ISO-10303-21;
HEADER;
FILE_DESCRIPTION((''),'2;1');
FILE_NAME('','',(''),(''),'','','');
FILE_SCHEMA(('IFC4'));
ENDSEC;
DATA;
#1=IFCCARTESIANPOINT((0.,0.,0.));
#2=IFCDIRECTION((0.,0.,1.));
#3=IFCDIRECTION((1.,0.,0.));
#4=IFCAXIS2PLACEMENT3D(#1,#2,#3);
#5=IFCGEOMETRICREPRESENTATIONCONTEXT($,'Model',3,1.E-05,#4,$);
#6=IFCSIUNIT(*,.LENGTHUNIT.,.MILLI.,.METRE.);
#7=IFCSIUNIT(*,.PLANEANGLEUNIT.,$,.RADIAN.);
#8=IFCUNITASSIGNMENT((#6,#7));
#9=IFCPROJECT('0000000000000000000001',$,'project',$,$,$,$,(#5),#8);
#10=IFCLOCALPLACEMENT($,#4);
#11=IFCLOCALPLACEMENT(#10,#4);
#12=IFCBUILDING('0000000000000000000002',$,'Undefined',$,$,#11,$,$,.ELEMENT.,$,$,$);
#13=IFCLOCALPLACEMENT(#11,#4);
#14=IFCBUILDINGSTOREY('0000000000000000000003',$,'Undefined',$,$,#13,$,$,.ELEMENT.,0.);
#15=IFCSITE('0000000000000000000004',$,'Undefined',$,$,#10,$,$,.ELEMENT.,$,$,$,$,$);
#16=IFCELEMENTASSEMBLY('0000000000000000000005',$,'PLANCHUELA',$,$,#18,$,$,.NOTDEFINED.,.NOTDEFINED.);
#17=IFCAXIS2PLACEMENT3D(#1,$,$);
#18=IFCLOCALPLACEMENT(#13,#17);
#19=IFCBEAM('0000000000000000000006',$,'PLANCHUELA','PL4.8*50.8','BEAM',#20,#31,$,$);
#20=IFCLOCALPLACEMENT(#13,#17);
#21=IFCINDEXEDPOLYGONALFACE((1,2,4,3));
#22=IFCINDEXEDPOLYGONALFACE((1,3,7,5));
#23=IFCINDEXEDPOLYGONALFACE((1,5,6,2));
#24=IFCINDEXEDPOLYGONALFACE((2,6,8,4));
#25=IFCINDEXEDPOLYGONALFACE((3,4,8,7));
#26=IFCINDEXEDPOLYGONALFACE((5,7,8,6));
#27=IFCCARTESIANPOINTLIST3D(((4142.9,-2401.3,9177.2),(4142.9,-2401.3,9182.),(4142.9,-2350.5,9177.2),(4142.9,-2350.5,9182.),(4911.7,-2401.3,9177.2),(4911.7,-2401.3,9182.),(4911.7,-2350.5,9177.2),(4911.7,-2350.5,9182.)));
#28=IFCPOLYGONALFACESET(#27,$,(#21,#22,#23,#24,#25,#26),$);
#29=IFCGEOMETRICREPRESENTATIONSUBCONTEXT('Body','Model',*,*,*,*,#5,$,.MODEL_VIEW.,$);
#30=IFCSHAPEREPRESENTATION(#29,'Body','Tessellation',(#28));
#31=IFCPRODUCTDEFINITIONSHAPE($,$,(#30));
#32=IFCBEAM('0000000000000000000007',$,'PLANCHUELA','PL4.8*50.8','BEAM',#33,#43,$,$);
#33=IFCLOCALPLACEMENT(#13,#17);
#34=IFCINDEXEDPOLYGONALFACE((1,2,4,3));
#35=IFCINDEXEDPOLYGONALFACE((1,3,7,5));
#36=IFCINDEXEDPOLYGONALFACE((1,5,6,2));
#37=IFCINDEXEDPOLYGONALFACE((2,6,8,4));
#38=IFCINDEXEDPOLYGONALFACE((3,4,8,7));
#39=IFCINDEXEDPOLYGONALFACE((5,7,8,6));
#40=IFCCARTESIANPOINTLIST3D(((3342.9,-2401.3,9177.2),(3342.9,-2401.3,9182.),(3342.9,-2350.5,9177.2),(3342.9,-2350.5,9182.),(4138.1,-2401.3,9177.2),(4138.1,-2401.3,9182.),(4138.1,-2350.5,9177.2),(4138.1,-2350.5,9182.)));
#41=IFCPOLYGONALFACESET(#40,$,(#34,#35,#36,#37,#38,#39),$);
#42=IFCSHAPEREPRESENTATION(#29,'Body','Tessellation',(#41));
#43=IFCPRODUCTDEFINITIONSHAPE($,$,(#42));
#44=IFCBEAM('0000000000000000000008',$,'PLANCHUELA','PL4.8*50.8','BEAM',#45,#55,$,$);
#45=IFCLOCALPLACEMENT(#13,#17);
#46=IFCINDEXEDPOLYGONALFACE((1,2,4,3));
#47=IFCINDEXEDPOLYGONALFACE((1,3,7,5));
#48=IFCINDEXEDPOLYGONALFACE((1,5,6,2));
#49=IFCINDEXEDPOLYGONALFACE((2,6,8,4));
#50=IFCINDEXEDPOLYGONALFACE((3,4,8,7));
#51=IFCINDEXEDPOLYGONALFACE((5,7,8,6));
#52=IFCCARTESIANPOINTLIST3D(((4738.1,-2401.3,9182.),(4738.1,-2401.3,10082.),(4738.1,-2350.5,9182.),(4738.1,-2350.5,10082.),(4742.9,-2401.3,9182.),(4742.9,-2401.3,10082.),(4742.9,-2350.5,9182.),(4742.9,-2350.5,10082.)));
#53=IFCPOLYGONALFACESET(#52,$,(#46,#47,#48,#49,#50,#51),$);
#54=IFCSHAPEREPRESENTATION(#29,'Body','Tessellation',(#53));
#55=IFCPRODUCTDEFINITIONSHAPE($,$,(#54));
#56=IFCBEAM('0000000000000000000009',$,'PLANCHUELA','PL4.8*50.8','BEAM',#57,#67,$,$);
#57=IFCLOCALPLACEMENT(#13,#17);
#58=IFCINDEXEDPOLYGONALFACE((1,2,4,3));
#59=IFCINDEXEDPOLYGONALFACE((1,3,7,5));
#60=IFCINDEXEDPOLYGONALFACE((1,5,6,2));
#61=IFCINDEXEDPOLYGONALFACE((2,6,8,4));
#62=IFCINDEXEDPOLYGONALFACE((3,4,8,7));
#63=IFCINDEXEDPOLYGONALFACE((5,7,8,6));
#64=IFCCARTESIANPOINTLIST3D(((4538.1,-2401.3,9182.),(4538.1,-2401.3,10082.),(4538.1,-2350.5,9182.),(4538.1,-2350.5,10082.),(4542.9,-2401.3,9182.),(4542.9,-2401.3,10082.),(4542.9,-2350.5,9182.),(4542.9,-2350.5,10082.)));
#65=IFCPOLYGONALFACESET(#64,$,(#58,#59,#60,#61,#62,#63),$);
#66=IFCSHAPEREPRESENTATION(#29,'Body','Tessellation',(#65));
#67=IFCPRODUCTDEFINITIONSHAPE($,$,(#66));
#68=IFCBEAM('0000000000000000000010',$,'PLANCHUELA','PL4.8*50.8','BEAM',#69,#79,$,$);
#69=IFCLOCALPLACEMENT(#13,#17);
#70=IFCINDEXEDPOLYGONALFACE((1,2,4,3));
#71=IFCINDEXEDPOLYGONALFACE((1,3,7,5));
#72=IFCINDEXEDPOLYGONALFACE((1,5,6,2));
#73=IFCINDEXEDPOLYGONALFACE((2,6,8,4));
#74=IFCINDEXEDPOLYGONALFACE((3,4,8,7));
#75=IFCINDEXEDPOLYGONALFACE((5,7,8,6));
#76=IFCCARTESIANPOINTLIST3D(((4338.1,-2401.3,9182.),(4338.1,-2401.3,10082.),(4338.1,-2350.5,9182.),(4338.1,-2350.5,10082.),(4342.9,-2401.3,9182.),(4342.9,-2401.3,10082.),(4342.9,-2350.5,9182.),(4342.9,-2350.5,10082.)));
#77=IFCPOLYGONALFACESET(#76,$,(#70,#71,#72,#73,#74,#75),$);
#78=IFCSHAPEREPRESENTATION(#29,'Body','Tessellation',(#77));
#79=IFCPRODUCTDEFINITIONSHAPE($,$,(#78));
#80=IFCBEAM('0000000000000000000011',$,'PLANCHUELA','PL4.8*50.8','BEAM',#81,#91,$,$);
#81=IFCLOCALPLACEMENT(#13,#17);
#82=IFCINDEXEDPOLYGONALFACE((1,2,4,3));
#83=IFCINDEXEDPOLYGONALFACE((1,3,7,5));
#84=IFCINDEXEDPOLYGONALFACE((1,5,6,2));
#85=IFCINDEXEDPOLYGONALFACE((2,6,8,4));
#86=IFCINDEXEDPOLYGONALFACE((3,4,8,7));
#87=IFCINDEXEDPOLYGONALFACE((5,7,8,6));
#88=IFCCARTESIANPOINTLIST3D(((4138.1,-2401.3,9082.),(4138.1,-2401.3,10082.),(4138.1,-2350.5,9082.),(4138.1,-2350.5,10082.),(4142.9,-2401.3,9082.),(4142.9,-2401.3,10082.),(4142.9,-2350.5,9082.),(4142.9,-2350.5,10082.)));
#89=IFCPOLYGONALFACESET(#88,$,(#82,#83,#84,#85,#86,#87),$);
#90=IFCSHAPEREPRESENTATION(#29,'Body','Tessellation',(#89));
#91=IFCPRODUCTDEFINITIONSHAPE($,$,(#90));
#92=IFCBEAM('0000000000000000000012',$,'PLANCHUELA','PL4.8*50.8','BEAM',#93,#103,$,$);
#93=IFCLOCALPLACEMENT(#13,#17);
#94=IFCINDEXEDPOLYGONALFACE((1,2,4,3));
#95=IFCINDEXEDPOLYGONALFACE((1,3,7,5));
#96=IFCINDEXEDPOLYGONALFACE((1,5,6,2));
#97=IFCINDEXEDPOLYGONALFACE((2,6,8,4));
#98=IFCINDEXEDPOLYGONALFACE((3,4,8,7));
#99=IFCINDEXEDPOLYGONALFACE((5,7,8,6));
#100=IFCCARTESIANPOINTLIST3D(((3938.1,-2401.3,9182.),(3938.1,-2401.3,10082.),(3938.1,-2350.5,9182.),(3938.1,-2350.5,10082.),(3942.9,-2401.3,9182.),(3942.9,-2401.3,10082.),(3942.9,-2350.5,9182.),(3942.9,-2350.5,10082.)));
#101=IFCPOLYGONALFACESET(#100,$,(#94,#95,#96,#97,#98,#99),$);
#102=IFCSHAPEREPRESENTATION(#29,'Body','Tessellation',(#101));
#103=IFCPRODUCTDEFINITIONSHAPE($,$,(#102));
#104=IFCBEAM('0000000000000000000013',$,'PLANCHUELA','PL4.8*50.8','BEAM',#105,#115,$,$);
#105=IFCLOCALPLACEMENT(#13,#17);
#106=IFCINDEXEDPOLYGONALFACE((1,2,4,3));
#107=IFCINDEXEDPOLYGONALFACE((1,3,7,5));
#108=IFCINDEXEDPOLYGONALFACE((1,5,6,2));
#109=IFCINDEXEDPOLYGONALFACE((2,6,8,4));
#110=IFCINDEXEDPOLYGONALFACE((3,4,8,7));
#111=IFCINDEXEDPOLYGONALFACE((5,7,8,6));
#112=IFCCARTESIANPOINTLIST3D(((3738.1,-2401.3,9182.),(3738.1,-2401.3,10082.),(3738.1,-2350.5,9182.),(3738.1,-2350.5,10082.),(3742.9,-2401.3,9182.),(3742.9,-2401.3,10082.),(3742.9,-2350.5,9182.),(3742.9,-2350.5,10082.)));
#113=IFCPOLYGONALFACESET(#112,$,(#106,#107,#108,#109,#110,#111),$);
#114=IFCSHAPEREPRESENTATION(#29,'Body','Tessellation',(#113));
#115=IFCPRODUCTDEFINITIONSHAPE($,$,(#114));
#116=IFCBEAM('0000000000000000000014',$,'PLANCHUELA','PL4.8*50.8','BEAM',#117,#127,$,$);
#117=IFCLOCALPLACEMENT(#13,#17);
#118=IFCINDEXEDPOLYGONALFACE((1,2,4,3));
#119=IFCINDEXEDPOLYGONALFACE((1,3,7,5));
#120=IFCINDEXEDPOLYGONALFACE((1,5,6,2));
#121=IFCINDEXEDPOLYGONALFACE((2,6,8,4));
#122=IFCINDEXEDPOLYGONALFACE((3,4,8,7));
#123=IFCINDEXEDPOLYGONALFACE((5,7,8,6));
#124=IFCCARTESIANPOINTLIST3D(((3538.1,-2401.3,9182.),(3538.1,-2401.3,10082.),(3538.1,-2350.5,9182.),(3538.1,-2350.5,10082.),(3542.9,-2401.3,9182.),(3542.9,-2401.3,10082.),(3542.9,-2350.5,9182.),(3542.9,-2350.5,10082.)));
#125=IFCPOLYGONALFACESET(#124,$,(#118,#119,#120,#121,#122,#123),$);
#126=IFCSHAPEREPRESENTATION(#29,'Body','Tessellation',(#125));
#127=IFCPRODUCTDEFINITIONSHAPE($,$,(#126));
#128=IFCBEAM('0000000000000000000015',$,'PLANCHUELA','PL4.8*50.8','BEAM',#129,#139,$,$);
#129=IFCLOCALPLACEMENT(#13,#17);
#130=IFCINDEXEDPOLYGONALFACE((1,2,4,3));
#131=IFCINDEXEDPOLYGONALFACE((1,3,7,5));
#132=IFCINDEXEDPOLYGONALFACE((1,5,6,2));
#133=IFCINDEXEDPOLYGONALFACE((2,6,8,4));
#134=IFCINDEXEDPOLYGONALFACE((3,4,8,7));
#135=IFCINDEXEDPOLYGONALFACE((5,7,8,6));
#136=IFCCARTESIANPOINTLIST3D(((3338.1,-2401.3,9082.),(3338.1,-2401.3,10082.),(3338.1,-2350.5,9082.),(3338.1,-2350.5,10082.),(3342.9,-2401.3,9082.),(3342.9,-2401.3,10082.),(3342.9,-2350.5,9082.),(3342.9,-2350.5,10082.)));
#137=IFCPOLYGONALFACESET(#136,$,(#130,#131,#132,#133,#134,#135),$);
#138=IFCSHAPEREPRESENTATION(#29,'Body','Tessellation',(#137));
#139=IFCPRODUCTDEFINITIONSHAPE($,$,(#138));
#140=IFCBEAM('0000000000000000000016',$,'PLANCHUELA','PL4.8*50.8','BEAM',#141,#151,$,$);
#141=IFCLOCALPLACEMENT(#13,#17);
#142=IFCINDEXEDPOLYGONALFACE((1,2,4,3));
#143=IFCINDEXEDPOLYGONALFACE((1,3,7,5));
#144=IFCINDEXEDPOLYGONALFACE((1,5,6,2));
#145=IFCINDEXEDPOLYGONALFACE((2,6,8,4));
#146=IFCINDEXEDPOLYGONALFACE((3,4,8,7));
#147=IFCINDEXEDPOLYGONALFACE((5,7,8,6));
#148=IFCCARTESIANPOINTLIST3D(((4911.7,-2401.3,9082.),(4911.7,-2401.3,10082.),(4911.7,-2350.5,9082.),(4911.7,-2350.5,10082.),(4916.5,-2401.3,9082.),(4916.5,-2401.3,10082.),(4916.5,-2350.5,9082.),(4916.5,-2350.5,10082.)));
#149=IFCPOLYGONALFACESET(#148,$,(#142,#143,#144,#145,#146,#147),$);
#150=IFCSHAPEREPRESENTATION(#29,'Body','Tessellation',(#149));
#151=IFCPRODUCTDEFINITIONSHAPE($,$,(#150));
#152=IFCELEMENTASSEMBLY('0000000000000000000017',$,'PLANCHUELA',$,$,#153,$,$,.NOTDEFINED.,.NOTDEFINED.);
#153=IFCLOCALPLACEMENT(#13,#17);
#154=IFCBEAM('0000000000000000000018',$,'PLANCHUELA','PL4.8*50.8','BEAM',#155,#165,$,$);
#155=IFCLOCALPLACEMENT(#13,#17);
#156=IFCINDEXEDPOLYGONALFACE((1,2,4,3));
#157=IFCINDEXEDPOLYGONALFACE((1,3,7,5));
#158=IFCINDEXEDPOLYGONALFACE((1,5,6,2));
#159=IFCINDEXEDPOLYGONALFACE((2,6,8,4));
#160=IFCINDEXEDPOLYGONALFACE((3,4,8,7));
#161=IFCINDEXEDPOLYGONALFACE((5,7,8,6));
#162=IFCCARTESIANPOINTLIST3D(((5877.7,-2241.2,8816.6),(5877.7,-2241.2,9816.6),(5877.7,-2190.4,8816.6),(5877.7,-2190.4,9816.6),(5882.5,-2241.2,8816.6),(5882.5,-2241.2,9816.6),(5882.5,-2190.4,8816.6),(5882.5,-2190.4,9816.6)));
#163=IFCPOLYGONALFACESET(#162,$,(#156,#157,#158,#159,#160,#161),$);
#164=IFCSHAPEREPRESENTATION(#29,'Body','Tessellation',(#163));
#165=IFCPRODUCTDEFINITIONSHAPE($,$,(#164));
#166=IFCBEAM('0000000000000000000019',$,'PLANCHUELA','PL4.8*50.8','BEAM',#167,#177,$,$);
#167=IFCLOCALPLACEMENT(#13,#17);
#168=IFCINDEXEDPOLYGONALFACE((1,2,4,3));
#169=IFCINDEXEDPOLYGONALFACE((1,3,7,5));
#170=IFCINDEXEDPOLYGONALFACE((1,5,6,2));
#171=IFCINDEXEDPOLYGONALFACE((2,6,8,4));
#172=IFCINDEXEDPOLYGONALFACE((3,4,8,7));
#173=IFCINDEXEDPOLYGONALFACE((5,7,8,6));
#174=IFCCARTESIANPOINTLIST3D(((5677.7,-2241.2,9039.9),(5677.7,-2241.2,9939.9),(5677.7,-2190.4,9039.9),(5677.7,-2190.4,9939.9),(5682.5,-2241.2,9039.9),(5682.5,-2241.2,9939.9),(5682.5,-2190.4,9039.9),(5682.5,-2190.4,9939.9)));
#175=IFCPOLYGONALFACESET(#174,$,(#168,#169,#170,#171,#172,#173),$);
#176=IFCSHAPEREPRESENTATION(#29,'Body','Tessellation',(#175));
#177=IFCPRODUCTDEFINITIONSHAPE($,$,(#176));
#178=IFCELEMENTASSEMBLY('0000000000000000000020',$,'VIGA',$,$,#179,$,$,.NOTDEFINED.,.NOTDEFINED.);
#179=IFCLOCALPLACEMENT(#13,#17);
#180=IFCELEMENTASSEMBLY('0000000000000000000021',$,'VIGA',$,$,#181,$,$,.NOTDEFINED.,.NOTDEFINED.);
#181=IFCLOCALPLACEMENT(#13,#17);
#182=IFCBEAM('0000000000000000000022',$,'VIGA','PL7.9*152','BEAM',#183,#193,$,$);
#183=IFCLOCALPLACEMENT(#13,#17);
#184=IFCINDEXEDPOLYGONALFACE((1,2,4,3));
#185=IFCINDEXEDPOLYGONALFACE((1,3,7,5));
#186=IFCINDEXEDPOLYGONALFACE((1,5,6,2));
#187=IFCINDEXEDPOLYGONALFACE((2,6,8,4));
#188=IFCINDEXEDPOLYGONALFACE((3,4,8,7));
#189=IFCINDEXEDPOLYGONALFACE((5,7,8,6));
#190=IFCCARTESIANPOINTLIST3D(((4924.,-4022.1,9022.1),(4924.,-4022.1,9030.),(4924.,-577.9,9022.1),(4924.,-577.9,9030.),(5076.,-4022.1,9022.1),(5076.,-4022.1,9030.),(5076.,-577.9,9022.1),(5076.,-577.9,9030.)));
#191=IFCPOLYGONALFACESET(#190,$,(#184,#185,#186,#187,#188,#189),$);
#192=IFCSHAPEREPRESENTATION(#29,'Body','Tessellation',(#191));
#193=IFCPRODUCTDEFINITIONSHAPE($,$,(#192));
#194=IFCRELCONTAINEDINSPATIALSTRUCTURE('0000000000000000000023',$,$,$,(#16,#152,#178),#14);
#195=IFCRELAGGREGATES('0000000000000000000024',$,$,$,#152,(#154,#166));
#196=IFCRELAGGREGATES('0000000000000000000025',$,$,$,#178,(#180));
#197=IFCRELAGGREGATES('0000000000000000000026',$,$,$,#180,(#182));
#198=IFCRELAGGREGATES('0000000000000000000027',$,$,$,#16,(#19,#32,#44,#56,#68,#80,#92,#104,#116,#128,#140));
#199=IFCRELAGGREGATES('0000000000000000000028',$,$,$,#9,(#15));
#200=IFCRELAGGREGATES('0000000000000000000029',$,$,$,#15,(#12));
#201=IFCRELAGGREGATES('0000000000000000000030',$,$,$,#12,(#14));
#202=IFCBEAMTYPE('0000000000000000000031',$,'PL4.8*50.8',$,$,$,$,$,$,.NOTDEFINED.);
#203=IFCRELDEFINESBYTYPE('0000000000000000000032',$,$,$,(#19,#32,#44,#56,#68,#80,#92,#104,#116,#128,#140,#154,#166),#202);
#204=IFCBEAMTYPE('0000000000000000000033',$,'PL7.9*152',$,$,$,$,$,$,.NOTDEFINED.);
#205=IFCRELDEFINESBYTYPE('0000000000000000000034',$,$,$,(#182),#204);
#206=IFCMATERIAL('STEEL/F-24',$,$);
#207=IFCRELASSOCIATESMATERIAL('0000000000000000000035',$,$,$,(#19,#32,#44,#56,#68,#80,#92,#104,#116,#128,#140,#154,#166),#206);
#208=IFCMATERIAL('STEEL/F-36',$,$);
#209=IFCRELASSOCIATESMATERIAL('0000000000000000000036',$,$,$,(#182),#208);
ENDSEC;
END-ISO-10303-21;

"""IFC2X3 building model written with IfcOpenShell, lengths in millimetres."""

from ifc_helpers import new_model, si_unit, frame, origin_with_axes, origin_2d_with_axis, place, context, subcontext, project, spatial, rectangle, extrude, material, type_object, element, aggregate, save


model = new_model("IFC2X3")

# Units and contexts
model_context = context("Model", 3, precision=1e-05, world=origin_with_axes())
body_context = subcontext(model_context, "Body", "Model", "MODEL_VIEW")
ifc_project = project(units=[si_unit("LENGTHUNIT", "METRE", prefix="MILLI"), si_unit("PLANEANGLEUNIT", "RADIAN")], contexts=[model_context])

# Site, building, storey
site_placement = place(None, origin_with_axes())
site = spatial("IfcSite", under=ifc_project, at=site_placement, Name="Undefined", CompositionType="ELEMENT")
building_placement = place(site_placement, origin_with_axes())
building = spatial("IfcBuilding", under=site, at=building_placement, Name="Undefined", CompositionType="ELEMENT")
storey_placement = place(building_placement, origin_with_axes())
storey = spatial("IfcBuildingStorey", under=building, at=storey_placement, Name="Undefined", CompositionType="ELEMENT", Elevation=0.0)

# Element assemblies, beams
assembly_1_placement = place(storey_placement, origin_with_axes())
assembly_1 = element("IfcElementAssembly", 1, at=assembly_1_placement, inside=storey, Name="PLANCHUELA", AssemblyPlace="NOTDEFINED", PredefinedType="NOTDEFINED")
ifc_material_1 = material(Name="STEEL/F-24")
beam_type_1 = type_object("IfcBeamType", Name="PL4.8*50.8", PredefinedType="NOTDEFINED")
beam_1_placement = place(assembly_1_placement, frame((4142.9, -2375.9, 9179.6), z_axis=(0.0, -1.0, 0.0), x_axis=(1.0, 0.0, 0.0)))
beam_1 = element("IfcBeam", 2, at=beam_1_placement, type_object=beam_type_1, material=ifc_material_1, Name="PLANCHUELA", Description="PL4.8*50.8", ObjectType="BEAM", context=body_context, shape_type="SweptSolid", body=[
    extrude(rectangle(XDim=4.8, YDim=50.8, at=origin_2d_with_axis()), frame((768.8, 0.0, 0.0), z_axis=(-1.0, 0.0, 0.0), x_axis=(0.0, -1.0, 0.0)), (0.0, 0.0, 1.0), 768.8),
])
beam_2_placement = place(assembly_1_placement, frame((3342.9, -2375.9, 9179.6), z_axis=(0.0, -1.0, 0.0), x_axis=(1.0, 0.0, 0.0)))
beam_2 = element("IfcBeam", 3, at=beam_2_placement, type_object=beam_type_1, material=ifc_material_1, Name="PLANCHUELA", Description="PL4.8*50.8", ObjectType="BEAM", context=body_context, shape_type="SweptSolid", body=[
    extrude(rectangle(XDim=4.8, YDim=50.8, at=origin_2d_with_axis()), frame((795.2, 0.0, 0.0), z_axis=(-1.0, 0.0, 0.0), x_axis=(0.0, -1.0, 0.0)), (0.0, 0.0, 1.0), 795.2),
])
beam_3_placement = place(assembly_1_placement, frame((4740.5, -2375.9, 10082.0), z_axis=(0.0, -1.0, 0.0), x_axis=(0.0, 0.0, -1.0)))
beam_3 = element("IfcBeam", 4, at=beam_3_placement, type_object=beam_type_1, material=ifc_material_1, Name="PLANCHUELA", Description="PL4.8*50.8", ObjectType="BEAM", context=body_context, shape_type="SweptSolid", body=[
    extrude(rectangle(XDim=4.8, YDim=50.8, at=origin_2d_with_axis()), frame((900.0, 0.0, 0.0), z_axis=(-1.0, 0.0, 0.0), x_axis=(0.0, -1.0, 0.0)), (0.0, 0.0, 1.0), 900.0),
])
beam_4_placement = place(assembly_1_placement, frame((4540.5, -2375.9, 10082.0), z_axis=(0.0, -1.0, 0.0), x_axis=(0.0, 0.0, -1.0)))
beam_4 = element("IfcBeam", 5, at=beam_4_placement, type_object=beam_type_1, material=ifc_material_1, Name="PLANCHUELA", Description="PL4.8*50.8", ObjectType="BEAM", context=body_context, shape_type="SweptSolid", body=[
    extrude(rectangle(XDim=4.8, YDim=50.8, at=origin_2d_with_axis()), frame((900.0, 0.0, 0.0), z_axis=(-1.0, 0.0, 0.0), x_axis=(0.0, -1.0, 0.0)), (0.0, 0.0, 1.0), 900.0),
])
beam_5_placement = place(assembly_1_placement, frame((4340.5, -2375.9, 10082.0), z_axis=(0.0, -1.0, 0.0), x_axis=(0.0, 0.0, -1.0)))
beam_5 = element("IfcBeam", 6, at=beam_5_placement, type_object=beam_type_1, material=ifc_material_1, Name="PLANCHUELA", Description="PL4.8*50.8", ObjectType="BEAM", context=body_context, shape_type="SweptSolid", body=[
    extrude(rectangle(XDim=4.8, YDim=50.8, at=origin_2d_with_axis()), frame((900.0, 0.0, 0.0), z_axis=(-1.0, 0.0, 0.0), x_axis=(0.0, -1.0, 0.0)), (0.0, 0.0, 1.0), 900.0),
])
beam_6_placement = place(assembly_1_placement, frame((4140.5, -2375.9, 10082.0), z_axis=(0.0, -1.0, 0.0), x_axis=(0.0, 0.0, -1.0)))
beam_6 = element("IfcBeam", 7, at=beam_6_placement, type_object=beam_type_1, material=ifc_material_1, Name="PLANCHUELA", Description="PL4.8*50.8", ObjectType="BEAM", context=body_context, shape_type="SweptSolid", body=[
    extrude(rectangle(XDim=4.8, YDim=50.8, at=origin_2d_with_axis()), frame((1000.0, 0.0, 0.0), z_axis=(-1.0, 0.0, 0.0), x_axis=(0.0, -1.0, 0.0)), (0.0, 0.0, 1.0), 1000.0),
])
beam_7_placement = place(assembly_1_placement, frame((3940.5, -2375.9, 10082.0), z_axis=(0.0, -1.0, 0.0), x_axis=(0.0, 0.0, -1.0)))
beam_7 = element("IfcBeam", 8, at=beam_7_placement, type_object=beam_type_1, material=ifc_material_1, Name="PLANCHUELA", Description="PL4.8*50.8", ObjectType="BEAM", context=body_context, shape_type="SweptSolid", body=[
    extrude(rectangle(XDim=4.8, YDim=50.8, at=origin_2d_with_axis()), frame((900.0, 0.0, 0.0), z_axis=(-1.0, 0.0, 0.0), x_axis=(0.0, -1.0, 0.0)), (0.0, 0.0, 1.0), 900.0),
])
beam_8_placement = place(assembly_1_placement, frame((3740.5, -2375.9, 10082.0), z_axis=(0.0, -1.0, 0.0), x_axis=(0.0, 0.0, -1.0)))
beam_8 = element("IfcBeam", 9, at=beam_8_placement, type_object=beam_type_1, material=ifc_material_1, Name="PLANCHUELA", Description="PL4.8*50.8", ObjectType="BEAM", context=body_context, shape_type="SweptSolid", body=[
    extrude(rectangle(XDim=4.8, YDim=50.8, at=origin_2d_with_axis()), frame((900.0, 0.0, 0.0), z_axis=(-1.0, 0.0, 0.0), x_axis=(0.0, -1.0, 0.0)), (0.0, 0.0, 1.0), 900.0),
])
beam_9_placement = place(assembly_1_placement, frame((3540.5, -2375.9, 10082.0), z_axis=(0.0, -1.0, 0.0), x_axis=(0.0, 0.0, -1.0)))
beam_9 = element("IfcBeam", 10, at=beam_9_placement, type_object=beam_type_1, material=ifc_material_1, Name="PLANCHUELA", Description="PL4.8*50.8", ObjectType="BEAM", context=body_context, shape_type="SweptSolid", body=[
    extrude(rectangle(XDim=4.8, YDim=50.8, at=origin_2d_with_axis()), frame((900.0, 0.0, 0.0), z_axis=(-1.0, 0.0, 0.0), x_axis=(0.0, -1.0, 0.0)), (0.0, 0.0, 1.0), 900.0),
])
beam_10_placement = place(assembly_1_placement, frame((3340.5, -2375.9, 10082.0), z_axis=(0.0, -1.0, 0.0), x_axis=(0.0, 0.0, -1.0)))
beam_10 = element("IfcBeam", 11, at=beam_10_placement, type_object=beam_type_1, material=ifc_material_1, Name="PLANCHUELA", Description="PL4.8*50.8", ObjectType="BEAM", context=body_context, shape_type="SweptSolid", body=[
    extrude(rectangle(XDim=4.8, YDim=50.8, at=origin_2d_with_axis()), frame((1000.0, 0.0, 0.0), z_axis=(-1.0, 0.0, 0.0), x_axis=(0.0, -1.0, 0.0)), (0.0, 0.0, 1.0), 1000.0),
])
beam_11_placement = place(assembly_1_placement, frame((4914.1, -2375.9, 10082.0), z_axis=(0.0, -1.0, 0.0), x_axis=(0.0, 0.0, -1.0)))
beam_11 = element("IfcBeam", 12, at=beam_11_placement, type_object=beam_type_1, material=ifc_material_1, Name="PLANCHUELA", Description="PL4.8*50.8", ObjectType="BEAM", context=body_context, shape_type="SweptSolid", body=[
    extrude(rectangle(XDim=4.8, YDim=50.8, at=origin_2d_with_axis()), frame((1000.0, 0.0, 0.0), z_axis=(-1.0, 0.0, 0.0), x_axis=(0.0, -1.0, 0.0)), (0.0, 0.0, 1.0), 1000.0),
])
assembly_2_placement = place(storey_placement, origin_with_axes())
assembly_2 = element("IfcElementAssembly", 13, at=assembly_2_placement, inside=storey, Name="PLANCHUELA", AssemblyPlace="NOTDEFINED", PredefinedType="NOTDEFINED")
beam_12_placement = place(assembly_2_placement, frame((5880.1, -2215.8, 9816.6), z_axis=(0.0, -1.0, 0.0), x_axis=(0.0, 0.0, -1.0)))
beam_12 = element("IfcBeam", 14, at=beam_12_placement, type_object=beam_type_1, material=ifc_material_1, Name="PLANCHUELA", Description="PL4.8*50.8", ObjectType="BEAM", context=body_context, shape_type="SweptSolid", body=[
    extrude(rectangle(XDim=4.8, YDim=50.8, at=origin_2d_with_axis()), frame((1000.0, 0.0, 0.0), z_axis=(-1.0, 0.0, 0.0), x_axis=(0.0, -1.0, 0.0)), (0.0, 0.0, 1.0), 1000.0),
])
beam_13_placement = place(assembly_2_placement, frame((5680.1, -2215.8, 9939.9), z_axis=(0.0, -1.0, 0.0), x_axis=(0.0, 0.0, -1.0)))
beam_13 = element("IfcBeam", 15, at=beam_13_placement, type_object=beam_type_1, material=ifc_material_1, Name="PLANCHUELA", Description="PL4.8*50.8", ObjectType="BEAM", context=body_context, shape_type="SweptSolid", body=[
    extrude(rectangle(XDim=4.8, YDim=50.8, at=origin_2d_with_axis()), frame((900.0, 0.0, 0.0), z_axis=(-1.0, 0.0, 0.0), x_axis=(0.0, -1.0, 0.0)), (0.0, 0.0, 1.0), 900.0),
])
aggregate(assembly_2, [beam_12, beam_13])

# Element assemblies, beam
assembly_3_placement = place(storey_placement, origin_with_axes())
assembly_3 = element("IfcElementAssembly", 16, at=assembly_3_placement, inside=storey, Name="VIGA", AssemblyPlace="NOTDEFINED", PredefinedType="NOTDEFINED")
assembly_4_placement = place(assembly_3_placement, origin_with_axes())
assembly_4 = element("IfcElementAssembly", 17, at=assembly_4_placement, Name="VIGA", AssemblyPlace="NOTDEFINED", PredefinedType="NOTDEFINED")
ifc_material_2 = material(Name="STEEL/F-36")
beam_type_2 = type_object("IfcBeamType", Name="PL7.9*152", PredefinedType="NOTDEFINED")
beam_14_placement = place(assembly_4_placement, frame((5000.0, -4022.1, 9026.0), z_axis=(-1.0, 0.0, 0.0), x_axis=(0.0, 1.0, 0.0)))
beam_14 = element("IfcBeam", 18, at=beam_14_placement, type_object=beam_type_2, material=ifc_material_2, Name="VIGA", Description="PL7.9*152", ObjectType="BEAM", context=body_context, shape_type="SweptSolid", body=[
    extrude(rectangle(XDim=7.9, YDim=152.0, at=origin_2d_with_axis()), frame((3444.2, 0.0, 0.0), z_axis=(-1.0, 0.0, 0.0), x_axis=(0.0, -1.0, 0.0)), (0.0, 0.0, 1.0), 3444.2),
])

aggregate(assembly_3, [assembly_4])

aggregate(assembly_4, [beam_14])
aggregate(assembly_1, [beam_1, beam_2, beam_3, beam_4, beam_5, beam_6, beam_7, beam_8, beam_9, beam_10, beam_11])

save(model, "model.ifc")
